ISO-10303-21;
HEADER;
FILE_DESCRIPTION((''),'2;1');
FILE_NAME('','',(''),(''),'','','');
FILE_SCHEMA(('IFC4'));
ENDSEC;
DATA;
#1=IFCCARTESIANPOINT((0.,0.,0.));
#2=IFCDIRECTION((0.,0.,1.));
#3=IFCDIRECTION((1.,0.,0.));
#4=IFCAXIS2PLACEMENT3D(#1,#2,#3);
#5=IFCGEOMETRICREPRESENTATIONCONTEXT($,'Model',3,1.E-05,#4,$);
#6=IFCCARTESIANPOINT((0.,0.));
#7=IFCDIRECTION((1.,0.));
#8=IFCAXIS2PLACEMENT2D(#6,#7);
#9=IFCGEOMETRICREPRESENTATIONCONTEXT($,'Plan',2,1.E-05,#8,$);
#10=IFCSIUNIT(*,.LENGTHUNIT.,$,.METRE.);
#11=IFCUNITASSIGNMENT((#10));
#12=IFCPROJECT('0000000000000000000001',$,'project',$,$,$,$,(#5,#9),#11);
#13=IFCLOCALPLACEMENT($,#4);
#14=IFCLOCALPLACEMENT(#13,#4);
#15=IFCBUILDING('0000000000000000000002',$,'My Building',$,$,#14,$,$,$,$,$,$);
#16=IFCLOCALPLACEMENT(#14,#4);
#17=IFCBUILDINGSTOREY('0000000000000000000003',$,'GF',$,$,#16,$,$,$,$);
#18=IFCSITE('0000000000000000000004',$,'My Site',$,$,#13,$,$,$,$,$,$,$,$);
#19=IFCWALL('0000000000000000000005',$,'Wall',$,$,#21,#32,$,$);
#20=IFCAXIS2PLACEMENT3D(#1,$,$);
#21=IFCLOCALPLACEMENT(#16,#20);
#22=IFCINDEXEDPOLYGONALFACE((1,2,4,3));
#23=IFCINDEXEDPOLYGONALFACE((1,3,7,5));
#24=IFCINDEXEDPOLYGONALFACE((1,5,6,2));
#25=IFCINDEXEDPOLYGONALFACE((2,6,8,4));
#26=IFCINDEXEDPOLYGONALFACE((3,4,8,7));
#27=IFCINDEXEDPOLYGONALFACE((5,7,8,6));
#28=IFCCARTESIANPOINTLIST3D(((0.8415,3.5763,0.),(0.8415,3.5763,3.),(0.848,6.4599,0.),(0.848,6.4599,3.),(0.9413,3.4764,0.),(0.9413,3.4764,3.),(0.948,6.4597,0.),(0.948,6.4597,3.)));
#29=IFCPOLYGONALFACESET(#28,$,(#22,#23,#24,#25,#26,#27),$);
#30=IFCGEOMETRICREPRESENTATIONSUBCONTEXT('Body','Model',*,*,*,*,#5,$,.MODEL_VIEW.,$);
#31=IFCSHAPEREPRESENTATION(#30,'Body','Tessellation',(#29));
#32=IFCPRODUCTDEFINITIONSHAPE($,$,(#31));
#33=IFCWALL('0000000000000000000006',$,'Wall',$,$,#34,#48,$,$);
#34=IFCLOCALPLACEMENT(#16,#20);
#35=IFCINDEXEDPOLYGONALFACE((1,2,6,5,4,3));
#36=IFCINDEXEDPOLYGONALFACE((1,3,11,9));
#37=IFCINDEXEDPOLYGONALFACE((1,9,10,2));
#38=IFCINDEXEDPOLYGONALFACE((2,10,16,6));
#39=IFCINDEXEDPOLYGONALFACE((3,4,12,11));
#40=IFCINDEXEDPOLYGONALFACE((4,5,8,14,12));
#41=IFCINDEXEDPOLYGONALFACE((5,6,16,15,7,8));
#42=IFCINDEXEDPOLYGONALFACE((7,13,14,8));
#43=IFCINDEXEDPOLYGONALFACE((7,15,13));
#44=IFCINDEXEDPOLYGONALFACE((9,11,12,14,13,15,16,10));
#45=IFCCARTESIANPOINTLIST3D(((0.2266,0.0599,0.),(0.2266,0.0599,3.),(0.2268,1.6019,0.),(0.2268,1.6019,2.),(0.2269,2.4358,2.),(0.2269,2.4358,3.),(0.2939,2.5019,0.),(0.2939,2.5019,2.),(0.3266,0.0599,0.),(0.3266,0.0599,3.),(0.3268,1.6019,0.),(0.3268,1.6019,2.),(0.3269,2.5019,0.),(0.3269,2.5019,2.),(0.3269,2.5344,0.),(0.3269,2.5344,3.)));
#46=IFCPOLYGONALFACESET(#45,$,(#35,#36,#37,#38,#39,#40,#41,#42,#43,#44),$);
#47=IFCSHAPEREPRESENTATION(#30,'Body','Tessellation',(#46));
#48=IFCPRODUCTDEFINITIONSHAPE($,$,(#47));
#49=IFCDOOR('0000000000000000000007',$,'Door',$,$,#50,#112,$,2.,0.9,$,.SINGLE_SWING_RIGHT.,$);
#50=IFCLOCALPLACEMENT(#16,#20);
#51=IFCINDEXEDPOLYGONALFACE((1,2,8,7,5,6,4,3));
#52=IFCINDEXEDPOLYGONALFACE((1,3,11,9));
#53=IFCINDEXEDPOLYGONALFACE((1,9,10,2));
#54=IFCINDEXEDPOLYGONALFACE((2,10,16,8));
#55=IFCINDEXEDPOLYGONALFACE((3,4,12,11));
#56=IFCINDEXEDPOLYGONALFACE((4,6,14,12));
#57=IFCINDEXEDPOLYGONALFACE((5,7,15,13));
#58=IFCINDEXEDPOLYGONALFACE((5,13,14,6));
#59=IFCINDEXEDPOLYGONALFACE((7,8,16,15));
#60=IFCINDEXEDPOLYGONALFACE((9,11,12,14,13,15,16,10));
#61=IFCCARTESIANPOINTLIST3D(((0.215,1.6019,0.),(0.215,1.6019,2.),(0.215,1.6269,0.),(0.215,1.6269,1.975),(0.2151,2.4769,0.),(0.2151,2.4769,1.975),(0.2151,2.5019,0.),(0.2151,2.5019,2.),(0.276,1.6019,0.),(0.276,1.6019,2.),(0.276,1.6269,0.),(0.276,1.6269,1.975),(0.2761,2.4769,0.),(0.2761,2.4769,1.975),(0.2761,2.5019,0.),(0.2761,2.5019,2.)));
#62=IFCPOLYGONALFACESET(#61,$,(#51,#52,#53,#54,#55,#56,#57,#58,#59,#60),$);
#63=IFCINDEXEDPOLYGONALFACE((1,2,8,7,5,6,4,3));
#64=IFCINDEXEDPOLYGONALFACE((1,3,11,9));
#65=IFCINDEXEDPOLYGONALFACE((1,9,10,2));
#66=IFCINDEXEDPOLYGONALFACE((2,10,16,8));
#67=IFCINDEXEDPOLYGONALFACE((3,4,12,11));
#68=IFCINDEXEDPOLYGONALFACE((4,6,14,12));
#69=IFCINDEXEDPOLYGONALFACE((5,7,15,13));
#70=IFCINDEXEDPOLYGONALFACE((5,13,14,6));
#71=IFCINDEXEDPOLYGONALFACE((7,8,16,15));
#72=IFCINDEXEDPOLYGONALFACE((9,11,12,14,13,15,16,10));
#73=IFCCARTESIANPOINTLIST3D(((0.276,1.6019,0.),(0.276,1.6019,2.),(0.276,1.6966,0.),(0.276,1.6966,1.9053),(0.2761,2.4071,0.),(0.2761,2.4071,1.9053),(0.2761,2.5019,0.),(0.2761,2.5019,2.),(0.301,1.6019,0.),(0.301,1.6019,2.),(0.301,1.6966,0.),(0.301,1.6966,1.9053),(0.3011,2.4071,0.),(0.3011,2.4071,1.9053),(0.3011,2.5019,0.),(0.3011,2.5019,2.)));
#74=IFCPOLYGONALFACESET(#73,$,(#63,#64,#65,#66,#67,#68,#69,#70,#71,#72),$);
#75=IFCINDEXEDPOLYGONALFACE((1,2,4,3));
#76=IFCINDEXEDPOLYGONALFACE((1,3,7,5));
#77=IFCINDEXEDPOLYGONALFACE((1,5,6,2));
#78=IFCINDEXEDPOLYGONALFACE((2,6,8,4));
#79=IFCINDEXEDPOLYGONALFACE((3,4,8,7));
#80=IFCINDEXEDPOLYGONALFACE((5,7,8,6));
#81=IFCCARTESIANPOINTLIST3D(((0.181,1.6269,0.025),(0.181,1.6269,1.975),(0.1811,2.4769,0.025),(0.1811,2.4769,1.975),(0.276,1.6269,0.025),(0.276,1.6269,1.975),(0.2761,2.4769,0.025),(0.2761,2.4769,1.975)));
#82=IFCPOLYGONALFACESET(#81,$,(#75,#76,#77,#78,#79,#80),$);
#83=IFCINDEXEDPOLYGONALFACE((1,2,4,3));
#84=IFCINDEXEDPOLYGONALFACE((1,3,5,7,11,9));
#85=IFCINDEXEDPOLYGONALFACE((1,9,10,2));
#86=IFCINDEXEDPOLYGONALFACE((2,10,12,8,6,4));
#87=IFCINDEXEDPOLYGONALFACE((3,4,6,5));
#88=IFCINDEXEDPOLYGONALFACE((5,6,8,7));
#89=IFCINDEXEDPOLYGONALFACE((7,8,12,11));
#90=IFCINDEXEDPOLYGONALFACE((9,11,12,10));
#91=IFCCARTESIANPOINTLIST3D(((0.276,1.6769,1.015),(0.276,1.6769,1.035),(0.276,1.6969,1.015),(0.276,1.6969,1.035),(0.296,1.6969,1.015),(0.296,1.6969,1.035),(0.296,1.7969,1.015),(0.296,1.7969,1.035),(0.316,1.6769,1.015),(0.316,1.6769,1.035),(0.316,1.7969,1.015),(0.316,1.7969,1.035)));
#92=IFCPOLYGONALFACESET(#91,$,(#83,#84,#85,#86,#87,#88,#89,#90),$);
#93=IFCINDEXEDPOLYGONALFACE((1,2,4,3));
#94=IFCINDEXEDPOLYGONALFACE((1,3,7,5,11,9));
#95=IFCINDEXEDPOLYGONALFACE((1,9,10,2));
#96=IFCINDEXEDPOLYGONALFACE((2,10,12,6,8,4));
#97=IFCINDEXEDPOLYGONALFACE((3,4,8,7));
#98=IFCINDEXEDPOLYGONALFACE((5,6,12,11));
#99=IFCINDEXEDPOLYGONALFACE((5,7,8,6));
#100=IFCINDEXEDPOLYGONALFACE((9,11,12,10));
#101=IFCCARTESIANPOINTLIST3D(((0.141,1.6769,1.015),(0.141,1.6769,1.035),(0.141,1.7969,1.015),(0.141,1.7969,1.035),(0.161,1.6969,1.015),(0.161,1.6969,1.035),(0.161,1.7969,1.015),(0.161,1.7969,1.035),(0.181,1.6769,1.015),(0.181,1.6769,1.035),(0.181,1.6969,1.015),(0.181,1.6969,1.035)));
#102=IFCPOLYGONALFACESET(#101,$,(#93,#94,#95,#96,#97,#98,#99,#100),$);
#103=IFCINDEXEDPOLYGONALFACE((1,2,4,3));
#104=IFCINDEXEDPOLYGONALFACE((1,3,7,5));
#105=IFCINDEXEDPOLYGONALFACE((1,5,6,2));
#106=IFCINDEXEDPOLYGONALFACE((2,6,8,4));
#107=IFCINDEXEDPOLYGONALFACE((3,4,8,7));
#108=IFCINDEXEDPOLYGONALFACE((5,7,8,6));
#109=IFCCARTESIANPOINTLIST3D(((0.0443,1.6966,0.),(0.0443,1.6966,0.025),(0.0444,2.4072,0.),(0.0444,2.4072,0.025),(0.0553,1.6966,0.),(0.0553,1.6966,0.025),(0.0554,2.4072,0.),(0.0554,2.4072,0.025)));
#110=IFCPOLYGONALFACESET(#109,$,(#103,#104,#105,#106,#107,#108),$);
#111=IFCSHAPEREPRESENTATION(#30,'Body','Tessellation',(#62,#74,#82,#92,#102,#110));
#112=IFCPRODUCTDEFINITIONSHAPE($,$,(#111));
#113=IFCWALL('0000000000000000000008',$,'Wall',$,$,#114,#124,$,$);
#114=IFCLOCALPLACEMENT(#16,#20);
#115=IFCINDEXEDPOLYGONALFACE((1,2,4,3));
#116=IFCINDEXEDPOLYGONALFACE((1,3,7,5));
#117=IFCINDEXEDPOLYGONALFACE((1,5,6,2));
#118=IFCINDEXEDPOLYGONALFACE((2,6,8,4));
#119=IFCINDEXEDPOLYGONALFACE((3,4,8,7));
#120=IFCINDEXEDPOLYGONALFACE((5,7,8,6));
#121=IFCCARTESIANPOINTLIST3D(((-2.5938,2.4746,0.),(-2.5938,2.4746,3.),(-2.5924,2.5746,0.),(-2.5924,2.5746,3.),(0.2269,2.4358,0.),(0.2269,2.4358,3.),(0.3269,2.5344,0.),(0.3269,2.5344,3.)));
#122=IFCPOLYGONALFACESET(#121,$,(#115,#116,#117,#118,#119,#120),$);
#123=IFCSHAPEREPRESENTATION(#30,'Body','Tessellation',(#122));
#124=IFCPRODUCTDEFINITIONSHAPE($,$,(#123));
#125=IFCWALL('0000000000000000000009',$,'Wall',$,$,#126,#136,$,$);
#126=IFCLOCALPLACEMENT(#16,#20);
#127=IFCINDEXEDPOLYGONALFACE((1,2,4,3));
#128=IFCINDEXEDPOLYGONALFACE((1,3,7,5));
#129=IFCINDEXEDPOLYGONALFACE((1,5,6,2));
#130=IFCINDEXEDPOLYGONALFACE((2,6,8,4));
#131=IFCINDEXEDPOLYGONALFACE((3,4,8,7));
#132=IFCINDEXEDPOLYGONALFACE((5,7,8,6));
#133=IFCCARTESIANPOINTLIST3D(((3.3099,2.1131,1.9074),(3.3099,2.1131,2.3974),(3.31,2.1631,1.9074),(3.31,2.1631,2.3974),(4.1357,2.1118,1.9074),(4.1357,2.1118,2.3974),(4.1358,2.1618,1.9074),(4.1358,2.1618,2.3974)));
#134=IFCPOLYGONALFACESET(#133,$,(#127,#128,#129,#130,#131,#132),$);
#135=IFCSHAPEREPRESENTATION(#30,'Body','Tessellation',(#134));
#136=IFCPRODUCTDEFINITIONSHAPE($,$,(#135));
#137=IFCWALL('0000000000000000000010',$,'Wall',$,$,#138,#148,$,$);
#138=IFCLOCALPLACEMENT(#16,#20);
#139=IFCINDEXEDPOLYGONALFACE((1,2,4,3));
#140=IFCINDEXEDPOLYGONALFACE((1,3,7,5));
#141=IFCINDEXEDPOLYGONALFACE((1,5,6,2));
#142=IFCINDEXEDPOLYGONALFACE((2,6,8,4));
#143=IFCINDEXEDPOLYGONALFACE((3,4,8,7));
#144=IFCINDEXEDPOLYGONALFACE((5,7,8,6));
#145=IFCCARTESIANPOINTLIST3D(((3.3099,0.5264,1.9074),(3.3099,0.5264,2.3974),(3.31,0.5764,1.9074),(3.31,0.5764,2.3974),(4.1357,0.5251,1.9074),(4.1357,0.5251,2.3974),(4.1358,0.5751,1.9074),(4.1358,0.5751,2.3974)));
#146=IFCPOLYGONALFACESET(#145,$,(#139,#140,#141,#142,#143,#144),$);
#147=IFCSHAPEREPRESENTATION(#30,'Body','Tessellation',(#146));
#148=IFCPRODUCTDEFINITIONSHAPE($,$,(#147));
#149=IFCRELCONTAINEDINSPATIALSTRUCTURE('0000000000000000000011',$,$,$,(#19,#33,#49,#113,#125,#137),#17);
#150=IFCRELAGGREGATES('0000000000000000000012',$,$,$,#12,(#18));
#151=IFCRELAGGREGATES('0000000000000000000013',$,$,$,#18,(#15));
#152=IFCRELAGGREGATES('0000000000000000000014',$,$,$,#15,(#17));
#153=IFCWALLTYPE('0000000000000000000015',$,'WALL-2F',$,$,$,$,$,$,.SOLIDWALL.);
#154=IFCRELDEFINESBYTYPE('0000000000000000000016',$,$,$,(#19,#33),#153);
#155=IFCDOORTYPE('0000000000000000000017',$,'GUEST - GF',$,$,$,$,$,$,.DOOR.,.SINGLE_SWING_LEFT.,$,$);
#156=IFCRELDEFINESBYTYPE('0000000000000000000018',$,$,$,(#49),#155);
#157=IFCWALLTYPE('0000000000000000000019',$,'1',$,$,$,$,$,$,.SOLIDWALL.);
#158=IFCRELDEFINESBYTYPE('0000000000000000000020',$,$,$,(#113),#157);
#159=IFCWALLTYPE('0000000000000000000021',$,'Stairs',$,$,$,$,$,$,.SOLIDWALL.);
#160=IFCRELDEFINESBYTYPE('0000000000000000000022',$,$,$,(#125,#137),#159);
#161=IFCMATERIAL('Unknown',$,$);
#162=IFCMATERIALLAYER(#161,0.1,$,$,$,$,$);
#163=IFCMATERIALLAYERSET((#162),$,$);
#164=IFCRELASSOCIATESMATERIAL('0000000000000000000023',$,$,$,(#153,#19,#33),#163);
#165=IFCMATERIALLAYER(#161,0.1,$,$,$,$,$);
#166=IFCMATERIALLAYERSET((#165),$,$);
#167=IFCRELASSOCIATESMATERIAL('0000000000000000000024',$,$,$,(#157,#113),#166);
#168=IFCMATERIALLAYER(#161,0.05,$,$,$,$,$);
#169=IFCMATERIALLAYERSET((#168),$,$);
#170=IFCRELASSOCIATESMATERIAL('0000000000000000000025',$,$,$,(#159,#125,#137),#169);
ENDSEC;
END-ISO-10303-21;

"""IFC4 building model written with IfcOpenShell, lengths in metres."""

from ifc_helpers import new_model, entity, si_unit, frame, origin_with_axes, origin_2d_with_axis, place, context, subcontext, project, spatial, line, indexed_curve, outline, extrude, shape, source, transform, mapped, material, layer, layer_set, layer_usage, type_object, type_shapes, element, fill, save


model = new_model("IFC4")

# Units and contexts
model_context = context("Model", 3, precision=1e-05, world=origin_with_axes())
plan_context = context("Plan", 2, precision=1e-05, world=origin_2d_with_axis())
body_context_1 = subcontext(model_context, "Body", "Model", "MODEL_VIEW")
body_context_2 = subcontext(plan_context, "Body", "Plan", "PLAN_VIEW")
ifc_project = project(units=[si_unit("LENGTHUNIT", "METRE")], contexts=[model_context, plan_context])

# Site, building, storey
site_placement = place(None, origin_with_axes())
site = spatial("IfcSite", under=ifc_project, at=site_placement, Name="My Site")
building_placement = place(site_placement, origin_with_axes())
building = spatial("IfcBuilding", under=site, at=building_placement, Name="My Building")
storey_placement = place(building_placement, origin_with_axes())
storey = spatial("IfcBuildingStorey", under=building, at=storey_placement, Name="GF")

# Shared definitions
ifc_material_1 = material(Name="Unknown")

# Shared definitions
ifc_layer_1 = layer(ifc_material_1, 0.1)
ifc_layer_set_1 = layer_set([ifc_layer_1])
wall_type_1 = type_object("IfcWallType", Name="WALL-2F", PredefinedType="SOLIDWALL", material=ifc_layer_set_1)

# Wall
ifc_layer_usage_1 = layer_usage(ifc_layer_set_1, "AXIS2", "POSITIVE", 0.0)
wall_1_placement = place(storey_placement, frame((0.848, 6.4599, 0.0), z_axis=(0.0, 0.0, 1.0), x_axis=(-0.00226, -0.999997, 0.0)))
element("IfcWall", 1, at=wall_1_placement, inside=storey, type_object=wall_type_1, material=ifc_layer_usage_1, Name="Wall", context=body_context_1, shape_type="SweptSolid", body=[
    extrude(outline(indexed_curve([(0.0, 0.0), (0.0, 0.1), (2.9833, 0.1), (2.8836, 0.0)], segments=[line(1, 2, 3, 4, 1)])), origin_with_axes(), (0.0, 0.0, 1.0), 3.0),
])

# Wall, opening, door
ifc_layer_usage_2 = layer_usage(ifc_layer_set_1, "AXIS2", "POSITIVE", 0.0)
wall_2_placement = place(storey_placement, frame((0.2269, 2.5358, 0.0), z_axis=(0.0, 0.0, 1.0), x_axis=(-0.000105, -1.0, 0.0)))
wall_2 = element("IfcWall", 2, at=wall_2_placement, inside=storey, type_object=wall_type_1, material=ifc_layer_usage_2, Name="Wall", context=body_context_1, shape_type="SweptSolid", body=[
    extrude(outline(indexed_curve([(0.1, 0.0), (0.0014, 0.1), (2.4759, 0.1), (2.4759, 0.0)], segments=[line(1, 2, 3, 4, 1)])), origin_with_axes(), (0.0, 0.0, 1.0), 3.0),
])
shared_shape_1 = source(origin_with_axes(), body_context_1, "Body", "SweptSolid", [
    extrude(outline(indexed_curve([(0.0, 0.0), (0.9, 0.0), (0.9, 2.0), (0.0, 2.0)], segments=[line(1, 2, 3, 4, 1)])), frame((0.0, -0.6, 0.0), z_axis=(0.0, -1.0, 0.0), x_axis=(1.0, 0.0, 0.0)), (0.0, 0.0, -1.0), 1.2),
])
opening_1_placement = place(wall_2_placement, frame((0.9339, 0.2103, 0.0), z_axis=(0.0, 0.0, 1.0), x_axis=(-1.0, 0.0, 0.0)))
opening_1 = element("IfcOpeningElement", 3, at=opening_1_placement, cuts=wall_2, PredefinedType="OPENING", context=body_context_1, shape_type="MappedRepresentation", body=[
    mapped(shared_shape_1, transform((0.0, 0.0, 0.0), x_axis=(1.0, 0.0, 0.0), y_axis=(0.0, 1.0, 0.0), z_axis=(0.0, 0.0, 1.0), scale=1.0)),
])
door_type_1 = type_object("IfcDoorType", Name="GUEST - GF", OperationType="SINGLE_SWING_LEFT", PredefinedType="DOOR")
shared_shape_2 = source(origin_with_axes(), body_context_1, "Body", "SweptSolid", [
    extrude(outline(indexed_curve([(0.0, 0.0), (0.0, 2.0), (0.9, 2.0), (0.9, 0.0), (0.875, 0.0), (0.875, 1.975), (0.025, 1.975), (0.025, 0.0)], segments=[line(1, 2, 3, 4, 5, 6, 7, 8, 1)])), frame((0.0, 0.0093, 0.0), z_axis=(0.0, -1.0, 0.0), x_axis=(1.0, 0.0, 0.0)), (0.0, 0.0, -1.0), 0.061),
    extrude(outline(indexed_curve([(0.0, 0.0), (0.0, 2.0), (0.9, 2.0), (0.9, 0.0), (0.8053, 0.0), (0.8053, 1.9053), (0.0947, 1.9053), (0.0947, 0.0)], segments=[line(1, 2, 3, 4, 5, 6, 7, 8, 1)])), frame((0.0, -0.0157, 0.0), z_axis=(0.0, -1.0, 0.0), x_axis=(1.0, 0.0, 0.0)), (0.0, 0.0, -1.0), 0.025),
    extrude(outline(indexed_curve([(0.0, 0.0), (0.85, 0.0), (0.85, 0.095), (0.0, 0.095)], segments=[line(1, 2, 3, 4, 1)])), frame((0.025, 0.0093, 0.025), z_axis=(0.0, 0.0, 1.0), x_axis=(1.0, 0.0, 0.0)), (0.0, 0.0, 1.0), 1.95),
    extrude(outline(indexed_curve([(0.0, 0.0), (0.0, -0.04), (0.12, -0.04), (0.12, -0.02), (0.02, -0.02), (0.02, 0.0)], segments=[line(1, 2, 3, 4, 5, 6, 1)])), frame((0.075, 0.0093, 1.015), z_axis=(0.0, 0.0, 1.0), x_axis=(1.0, 0.0, 0.0)), (0.0, 0.0, 1.0), 0.02),
    extrude(outline(indexed_curve([(0.0, 0.0), (0.0, 0.04), (0.12, 0.04), (0.12, 0.02), (0.02, 0.02), (0.02, 0.0)], segments=[line(1, 2, 3, 4, 5, 6, 1)])), frame((0.075, 0.1043, 1.015), z_axis=(0.0, 0.0, 1.0), x_axis=(1.0, 0.0, 0.0)), (0.0, 0.0, 1.0), 0.02),
    extrude(outline(indexed_curve([(0.0, 0.0), (0.7105, 0.0), (0.7105, 0.011), (0.0, 0.011)], segments=[line(1, 2, 3, 4, 1)])), frame((0.0947, 0.23, 0.0), z_axis=(0.0, 0.0, 1.0), x_axis=(1.0, 0.0, 0.0)), (0.0, 0.0, 1.0), 0.025),
])
shared_shape_3 = source(origin_with_axes(), body_context_2, "Body", "Curve2D", [
    entity("IfcIndexedPolyCurve", entity("IfcCartesianPointList2D", [[0.0, -0.0157], [0.0, 0.0703], [0.025, 0.0703], [0.025, 0.0093], [0.0947, 0.0093], [0.0947, -0.0157]]), [entity("IfcLineIndex", [1, 2, 3, 4, 5, 6, 1])]),
    entity("IfcIndexedPolyCurve", entity("IfcCartesianPointList2D", [[0.9, -0.0157], [0.9, 0.0703], [0.875, 0.0703], [0.875, 0.0093], [0.8053, 0.0093], [0.8053, -0.0157]]), [entity("IfcLineIndex", [1, 2, 3, 4, 5, 6, 1])]),
    entity("IfcTrimmedCurve", entity("IfcEllipse", entity("IfcAxis2Placement2D", entity("IfcCartesianPoint", [0.78, 0.0703]), entity("IfcDirection", [1.0, 0.0])), 0.755, 0.85), [entity("IfcCartesianPoint", [0.78, 0.9203])], [entity("IfcCartesianPoint", [0.025, 0.0703])], True, "CARTESIAN"),
    entity("IfcIndexedPolyCurve", entity("IfcCartesianPointList2D", [[0.875, 0.0703], [0.78, 0.0703], [0.78, 0.9203], [0.875, 0.9203]]), [entity("IfcLineIndex", [1, 2, 3, 4, 1])]),
])
type_shapes(door_type_1, [shared_shape_2, shared_shape_3])
door_1_placement = place(opening_1_placement, frame((0.0, 0.1518, 0.0), z_axis=(0.0, 0.0, 1.0), x_axis=(1.0, 0.0, 0.0)))
door_1 = element("IfcDoor", 4, at=door_1_placement, inside=storey, type_object=door_type_1, Name="Door", OperationType="SINGLE_SWING_RIGHT", OverallHeight=2.0, OverallWidth=0.9, shapes=[
    shape(body_context_1, "Body", "MappedRepresentation", [mapped(shared_shape_2, transform((0.0, 0.0, 0.0), x_axis=(1.0, 0.0, 0.0), y_axis=(0.0, 1.0, 0.0), z_axis=(0.0, 0.0, 1.0), scale=1.0))]),
    shape(body_context_2, "Body", "MappedRepresentation", [mapped(shared_shape_3, transform((0.0, 0.0, 0.0), x_axis=(1.0, 0.0, 0.0), y_axis=(0.0, 1.0, 0.0), z_axis=(0.0, 0.0, 1.0), scale=1.0))]),
])
fill(opening_1, door_1)

# Wall
ifc_layer_2 = layer(ifc_material_1, 0.1)
ifc_layer_set_2 = layer_set([ifc_layer_2])
ifc_layer_usage_3 = layer_usage(ifc_layer_set_2, "AXIS2", "POSITIVE", 0.0)
wall_type_2 = type_object("IfcWallType", Name="1", PredefinedType="SOLIDWALL", material=ifc_layer_set_2)
wall_3_placement = place(storey_placement, frame((0.2269, 2.5358, 0.0), z_axis=(0.0, 0.0, 1.0), x_axis=(-0.999905, 0.013761, 0.0)))
element("IfcWall", 5, at=wall_3_placement, inside=storey, type_object=wall_type_2, material=ifc_layer_usage_3, Name="Wall", context=body_context_1, shape_type="SweptSolid", body=[
    extrude(outline(indexed_curve([(-0.1, 0.0), (-0.0014, 0.1), (2.8195, 0.1), (2.8195, 0.0)], segments=[line(1, 2, 3, 4, 1)])), origin_with_axes(), (0.0, 0.0, 1.0), 3.0),
])

# Walls
ifc_layer_3 = layer(ifc_material_1, 0.05)
ifc_layer_set_3 = layer_set([ifc_layer_3])
ifc_layer_usage_4 = layer_usage(ifc_layer_set_3, "AXIS2", "POSITIVE", 0.0)
wall_type_3 = type_object("IfcWallType", Name="Stairs", PredefinedType="SOLIDWALL", material=ifc_layer_set_3)
wall_4_placement = place(storey_placement, frame((3.3099, 2.1131, 1.9074), z_axis=(0.0, 0.0, 1.0), x_axis=(0.999999, -0.001614, 0.0)))
element("IfcWall", 6, at=wall_4_placement, inside=storey, type_object=wall_type_3, material=ifc_layer_usage_4, Name="Wall", context=body_context_1, shape_type="SweptSolid", body=[
    extrude(outline(indexed_curve([(0.0, 0.0), (0.0, 0.05), (0.8258, 0.05), (0.8258, 0.0)], segments=[line(1, 2, 3, 4, 1)])), origin_with_axes(), (0.0, 0.0, 1.0), 0.49),
])
ifc_layer_usage_5 = layer_usage(ifc_layer_set_3, "AXIS2", "POSITIVE", 0.0)
wall_5_placement = place(storey_placement, frame((3.3099, 0.5264, 1.9074), z_axis=(0.0, 0.0, 1.0), x_axis=(0.999999, -0.001614, 0.0)))
element("IfcWall", 7, at=wall_5_placement, inside=storey, type_object=wall_type_3, material=ifc_layer_usage_5, Name="Wall", context=body_context_1, shape_type="SweptSolid", body=[
    extrude(outline(indexed_curve([(0.0, 0.0), (0.0, 0.05), (0.8258, 0.05), (0.8258, 0.0)], segments=[line(1, 2, 3, 4, 1)])), origin_with_axes(), (0.0, 0.0, 1.0), 0.49),
])

save(model, "model.ifc")
